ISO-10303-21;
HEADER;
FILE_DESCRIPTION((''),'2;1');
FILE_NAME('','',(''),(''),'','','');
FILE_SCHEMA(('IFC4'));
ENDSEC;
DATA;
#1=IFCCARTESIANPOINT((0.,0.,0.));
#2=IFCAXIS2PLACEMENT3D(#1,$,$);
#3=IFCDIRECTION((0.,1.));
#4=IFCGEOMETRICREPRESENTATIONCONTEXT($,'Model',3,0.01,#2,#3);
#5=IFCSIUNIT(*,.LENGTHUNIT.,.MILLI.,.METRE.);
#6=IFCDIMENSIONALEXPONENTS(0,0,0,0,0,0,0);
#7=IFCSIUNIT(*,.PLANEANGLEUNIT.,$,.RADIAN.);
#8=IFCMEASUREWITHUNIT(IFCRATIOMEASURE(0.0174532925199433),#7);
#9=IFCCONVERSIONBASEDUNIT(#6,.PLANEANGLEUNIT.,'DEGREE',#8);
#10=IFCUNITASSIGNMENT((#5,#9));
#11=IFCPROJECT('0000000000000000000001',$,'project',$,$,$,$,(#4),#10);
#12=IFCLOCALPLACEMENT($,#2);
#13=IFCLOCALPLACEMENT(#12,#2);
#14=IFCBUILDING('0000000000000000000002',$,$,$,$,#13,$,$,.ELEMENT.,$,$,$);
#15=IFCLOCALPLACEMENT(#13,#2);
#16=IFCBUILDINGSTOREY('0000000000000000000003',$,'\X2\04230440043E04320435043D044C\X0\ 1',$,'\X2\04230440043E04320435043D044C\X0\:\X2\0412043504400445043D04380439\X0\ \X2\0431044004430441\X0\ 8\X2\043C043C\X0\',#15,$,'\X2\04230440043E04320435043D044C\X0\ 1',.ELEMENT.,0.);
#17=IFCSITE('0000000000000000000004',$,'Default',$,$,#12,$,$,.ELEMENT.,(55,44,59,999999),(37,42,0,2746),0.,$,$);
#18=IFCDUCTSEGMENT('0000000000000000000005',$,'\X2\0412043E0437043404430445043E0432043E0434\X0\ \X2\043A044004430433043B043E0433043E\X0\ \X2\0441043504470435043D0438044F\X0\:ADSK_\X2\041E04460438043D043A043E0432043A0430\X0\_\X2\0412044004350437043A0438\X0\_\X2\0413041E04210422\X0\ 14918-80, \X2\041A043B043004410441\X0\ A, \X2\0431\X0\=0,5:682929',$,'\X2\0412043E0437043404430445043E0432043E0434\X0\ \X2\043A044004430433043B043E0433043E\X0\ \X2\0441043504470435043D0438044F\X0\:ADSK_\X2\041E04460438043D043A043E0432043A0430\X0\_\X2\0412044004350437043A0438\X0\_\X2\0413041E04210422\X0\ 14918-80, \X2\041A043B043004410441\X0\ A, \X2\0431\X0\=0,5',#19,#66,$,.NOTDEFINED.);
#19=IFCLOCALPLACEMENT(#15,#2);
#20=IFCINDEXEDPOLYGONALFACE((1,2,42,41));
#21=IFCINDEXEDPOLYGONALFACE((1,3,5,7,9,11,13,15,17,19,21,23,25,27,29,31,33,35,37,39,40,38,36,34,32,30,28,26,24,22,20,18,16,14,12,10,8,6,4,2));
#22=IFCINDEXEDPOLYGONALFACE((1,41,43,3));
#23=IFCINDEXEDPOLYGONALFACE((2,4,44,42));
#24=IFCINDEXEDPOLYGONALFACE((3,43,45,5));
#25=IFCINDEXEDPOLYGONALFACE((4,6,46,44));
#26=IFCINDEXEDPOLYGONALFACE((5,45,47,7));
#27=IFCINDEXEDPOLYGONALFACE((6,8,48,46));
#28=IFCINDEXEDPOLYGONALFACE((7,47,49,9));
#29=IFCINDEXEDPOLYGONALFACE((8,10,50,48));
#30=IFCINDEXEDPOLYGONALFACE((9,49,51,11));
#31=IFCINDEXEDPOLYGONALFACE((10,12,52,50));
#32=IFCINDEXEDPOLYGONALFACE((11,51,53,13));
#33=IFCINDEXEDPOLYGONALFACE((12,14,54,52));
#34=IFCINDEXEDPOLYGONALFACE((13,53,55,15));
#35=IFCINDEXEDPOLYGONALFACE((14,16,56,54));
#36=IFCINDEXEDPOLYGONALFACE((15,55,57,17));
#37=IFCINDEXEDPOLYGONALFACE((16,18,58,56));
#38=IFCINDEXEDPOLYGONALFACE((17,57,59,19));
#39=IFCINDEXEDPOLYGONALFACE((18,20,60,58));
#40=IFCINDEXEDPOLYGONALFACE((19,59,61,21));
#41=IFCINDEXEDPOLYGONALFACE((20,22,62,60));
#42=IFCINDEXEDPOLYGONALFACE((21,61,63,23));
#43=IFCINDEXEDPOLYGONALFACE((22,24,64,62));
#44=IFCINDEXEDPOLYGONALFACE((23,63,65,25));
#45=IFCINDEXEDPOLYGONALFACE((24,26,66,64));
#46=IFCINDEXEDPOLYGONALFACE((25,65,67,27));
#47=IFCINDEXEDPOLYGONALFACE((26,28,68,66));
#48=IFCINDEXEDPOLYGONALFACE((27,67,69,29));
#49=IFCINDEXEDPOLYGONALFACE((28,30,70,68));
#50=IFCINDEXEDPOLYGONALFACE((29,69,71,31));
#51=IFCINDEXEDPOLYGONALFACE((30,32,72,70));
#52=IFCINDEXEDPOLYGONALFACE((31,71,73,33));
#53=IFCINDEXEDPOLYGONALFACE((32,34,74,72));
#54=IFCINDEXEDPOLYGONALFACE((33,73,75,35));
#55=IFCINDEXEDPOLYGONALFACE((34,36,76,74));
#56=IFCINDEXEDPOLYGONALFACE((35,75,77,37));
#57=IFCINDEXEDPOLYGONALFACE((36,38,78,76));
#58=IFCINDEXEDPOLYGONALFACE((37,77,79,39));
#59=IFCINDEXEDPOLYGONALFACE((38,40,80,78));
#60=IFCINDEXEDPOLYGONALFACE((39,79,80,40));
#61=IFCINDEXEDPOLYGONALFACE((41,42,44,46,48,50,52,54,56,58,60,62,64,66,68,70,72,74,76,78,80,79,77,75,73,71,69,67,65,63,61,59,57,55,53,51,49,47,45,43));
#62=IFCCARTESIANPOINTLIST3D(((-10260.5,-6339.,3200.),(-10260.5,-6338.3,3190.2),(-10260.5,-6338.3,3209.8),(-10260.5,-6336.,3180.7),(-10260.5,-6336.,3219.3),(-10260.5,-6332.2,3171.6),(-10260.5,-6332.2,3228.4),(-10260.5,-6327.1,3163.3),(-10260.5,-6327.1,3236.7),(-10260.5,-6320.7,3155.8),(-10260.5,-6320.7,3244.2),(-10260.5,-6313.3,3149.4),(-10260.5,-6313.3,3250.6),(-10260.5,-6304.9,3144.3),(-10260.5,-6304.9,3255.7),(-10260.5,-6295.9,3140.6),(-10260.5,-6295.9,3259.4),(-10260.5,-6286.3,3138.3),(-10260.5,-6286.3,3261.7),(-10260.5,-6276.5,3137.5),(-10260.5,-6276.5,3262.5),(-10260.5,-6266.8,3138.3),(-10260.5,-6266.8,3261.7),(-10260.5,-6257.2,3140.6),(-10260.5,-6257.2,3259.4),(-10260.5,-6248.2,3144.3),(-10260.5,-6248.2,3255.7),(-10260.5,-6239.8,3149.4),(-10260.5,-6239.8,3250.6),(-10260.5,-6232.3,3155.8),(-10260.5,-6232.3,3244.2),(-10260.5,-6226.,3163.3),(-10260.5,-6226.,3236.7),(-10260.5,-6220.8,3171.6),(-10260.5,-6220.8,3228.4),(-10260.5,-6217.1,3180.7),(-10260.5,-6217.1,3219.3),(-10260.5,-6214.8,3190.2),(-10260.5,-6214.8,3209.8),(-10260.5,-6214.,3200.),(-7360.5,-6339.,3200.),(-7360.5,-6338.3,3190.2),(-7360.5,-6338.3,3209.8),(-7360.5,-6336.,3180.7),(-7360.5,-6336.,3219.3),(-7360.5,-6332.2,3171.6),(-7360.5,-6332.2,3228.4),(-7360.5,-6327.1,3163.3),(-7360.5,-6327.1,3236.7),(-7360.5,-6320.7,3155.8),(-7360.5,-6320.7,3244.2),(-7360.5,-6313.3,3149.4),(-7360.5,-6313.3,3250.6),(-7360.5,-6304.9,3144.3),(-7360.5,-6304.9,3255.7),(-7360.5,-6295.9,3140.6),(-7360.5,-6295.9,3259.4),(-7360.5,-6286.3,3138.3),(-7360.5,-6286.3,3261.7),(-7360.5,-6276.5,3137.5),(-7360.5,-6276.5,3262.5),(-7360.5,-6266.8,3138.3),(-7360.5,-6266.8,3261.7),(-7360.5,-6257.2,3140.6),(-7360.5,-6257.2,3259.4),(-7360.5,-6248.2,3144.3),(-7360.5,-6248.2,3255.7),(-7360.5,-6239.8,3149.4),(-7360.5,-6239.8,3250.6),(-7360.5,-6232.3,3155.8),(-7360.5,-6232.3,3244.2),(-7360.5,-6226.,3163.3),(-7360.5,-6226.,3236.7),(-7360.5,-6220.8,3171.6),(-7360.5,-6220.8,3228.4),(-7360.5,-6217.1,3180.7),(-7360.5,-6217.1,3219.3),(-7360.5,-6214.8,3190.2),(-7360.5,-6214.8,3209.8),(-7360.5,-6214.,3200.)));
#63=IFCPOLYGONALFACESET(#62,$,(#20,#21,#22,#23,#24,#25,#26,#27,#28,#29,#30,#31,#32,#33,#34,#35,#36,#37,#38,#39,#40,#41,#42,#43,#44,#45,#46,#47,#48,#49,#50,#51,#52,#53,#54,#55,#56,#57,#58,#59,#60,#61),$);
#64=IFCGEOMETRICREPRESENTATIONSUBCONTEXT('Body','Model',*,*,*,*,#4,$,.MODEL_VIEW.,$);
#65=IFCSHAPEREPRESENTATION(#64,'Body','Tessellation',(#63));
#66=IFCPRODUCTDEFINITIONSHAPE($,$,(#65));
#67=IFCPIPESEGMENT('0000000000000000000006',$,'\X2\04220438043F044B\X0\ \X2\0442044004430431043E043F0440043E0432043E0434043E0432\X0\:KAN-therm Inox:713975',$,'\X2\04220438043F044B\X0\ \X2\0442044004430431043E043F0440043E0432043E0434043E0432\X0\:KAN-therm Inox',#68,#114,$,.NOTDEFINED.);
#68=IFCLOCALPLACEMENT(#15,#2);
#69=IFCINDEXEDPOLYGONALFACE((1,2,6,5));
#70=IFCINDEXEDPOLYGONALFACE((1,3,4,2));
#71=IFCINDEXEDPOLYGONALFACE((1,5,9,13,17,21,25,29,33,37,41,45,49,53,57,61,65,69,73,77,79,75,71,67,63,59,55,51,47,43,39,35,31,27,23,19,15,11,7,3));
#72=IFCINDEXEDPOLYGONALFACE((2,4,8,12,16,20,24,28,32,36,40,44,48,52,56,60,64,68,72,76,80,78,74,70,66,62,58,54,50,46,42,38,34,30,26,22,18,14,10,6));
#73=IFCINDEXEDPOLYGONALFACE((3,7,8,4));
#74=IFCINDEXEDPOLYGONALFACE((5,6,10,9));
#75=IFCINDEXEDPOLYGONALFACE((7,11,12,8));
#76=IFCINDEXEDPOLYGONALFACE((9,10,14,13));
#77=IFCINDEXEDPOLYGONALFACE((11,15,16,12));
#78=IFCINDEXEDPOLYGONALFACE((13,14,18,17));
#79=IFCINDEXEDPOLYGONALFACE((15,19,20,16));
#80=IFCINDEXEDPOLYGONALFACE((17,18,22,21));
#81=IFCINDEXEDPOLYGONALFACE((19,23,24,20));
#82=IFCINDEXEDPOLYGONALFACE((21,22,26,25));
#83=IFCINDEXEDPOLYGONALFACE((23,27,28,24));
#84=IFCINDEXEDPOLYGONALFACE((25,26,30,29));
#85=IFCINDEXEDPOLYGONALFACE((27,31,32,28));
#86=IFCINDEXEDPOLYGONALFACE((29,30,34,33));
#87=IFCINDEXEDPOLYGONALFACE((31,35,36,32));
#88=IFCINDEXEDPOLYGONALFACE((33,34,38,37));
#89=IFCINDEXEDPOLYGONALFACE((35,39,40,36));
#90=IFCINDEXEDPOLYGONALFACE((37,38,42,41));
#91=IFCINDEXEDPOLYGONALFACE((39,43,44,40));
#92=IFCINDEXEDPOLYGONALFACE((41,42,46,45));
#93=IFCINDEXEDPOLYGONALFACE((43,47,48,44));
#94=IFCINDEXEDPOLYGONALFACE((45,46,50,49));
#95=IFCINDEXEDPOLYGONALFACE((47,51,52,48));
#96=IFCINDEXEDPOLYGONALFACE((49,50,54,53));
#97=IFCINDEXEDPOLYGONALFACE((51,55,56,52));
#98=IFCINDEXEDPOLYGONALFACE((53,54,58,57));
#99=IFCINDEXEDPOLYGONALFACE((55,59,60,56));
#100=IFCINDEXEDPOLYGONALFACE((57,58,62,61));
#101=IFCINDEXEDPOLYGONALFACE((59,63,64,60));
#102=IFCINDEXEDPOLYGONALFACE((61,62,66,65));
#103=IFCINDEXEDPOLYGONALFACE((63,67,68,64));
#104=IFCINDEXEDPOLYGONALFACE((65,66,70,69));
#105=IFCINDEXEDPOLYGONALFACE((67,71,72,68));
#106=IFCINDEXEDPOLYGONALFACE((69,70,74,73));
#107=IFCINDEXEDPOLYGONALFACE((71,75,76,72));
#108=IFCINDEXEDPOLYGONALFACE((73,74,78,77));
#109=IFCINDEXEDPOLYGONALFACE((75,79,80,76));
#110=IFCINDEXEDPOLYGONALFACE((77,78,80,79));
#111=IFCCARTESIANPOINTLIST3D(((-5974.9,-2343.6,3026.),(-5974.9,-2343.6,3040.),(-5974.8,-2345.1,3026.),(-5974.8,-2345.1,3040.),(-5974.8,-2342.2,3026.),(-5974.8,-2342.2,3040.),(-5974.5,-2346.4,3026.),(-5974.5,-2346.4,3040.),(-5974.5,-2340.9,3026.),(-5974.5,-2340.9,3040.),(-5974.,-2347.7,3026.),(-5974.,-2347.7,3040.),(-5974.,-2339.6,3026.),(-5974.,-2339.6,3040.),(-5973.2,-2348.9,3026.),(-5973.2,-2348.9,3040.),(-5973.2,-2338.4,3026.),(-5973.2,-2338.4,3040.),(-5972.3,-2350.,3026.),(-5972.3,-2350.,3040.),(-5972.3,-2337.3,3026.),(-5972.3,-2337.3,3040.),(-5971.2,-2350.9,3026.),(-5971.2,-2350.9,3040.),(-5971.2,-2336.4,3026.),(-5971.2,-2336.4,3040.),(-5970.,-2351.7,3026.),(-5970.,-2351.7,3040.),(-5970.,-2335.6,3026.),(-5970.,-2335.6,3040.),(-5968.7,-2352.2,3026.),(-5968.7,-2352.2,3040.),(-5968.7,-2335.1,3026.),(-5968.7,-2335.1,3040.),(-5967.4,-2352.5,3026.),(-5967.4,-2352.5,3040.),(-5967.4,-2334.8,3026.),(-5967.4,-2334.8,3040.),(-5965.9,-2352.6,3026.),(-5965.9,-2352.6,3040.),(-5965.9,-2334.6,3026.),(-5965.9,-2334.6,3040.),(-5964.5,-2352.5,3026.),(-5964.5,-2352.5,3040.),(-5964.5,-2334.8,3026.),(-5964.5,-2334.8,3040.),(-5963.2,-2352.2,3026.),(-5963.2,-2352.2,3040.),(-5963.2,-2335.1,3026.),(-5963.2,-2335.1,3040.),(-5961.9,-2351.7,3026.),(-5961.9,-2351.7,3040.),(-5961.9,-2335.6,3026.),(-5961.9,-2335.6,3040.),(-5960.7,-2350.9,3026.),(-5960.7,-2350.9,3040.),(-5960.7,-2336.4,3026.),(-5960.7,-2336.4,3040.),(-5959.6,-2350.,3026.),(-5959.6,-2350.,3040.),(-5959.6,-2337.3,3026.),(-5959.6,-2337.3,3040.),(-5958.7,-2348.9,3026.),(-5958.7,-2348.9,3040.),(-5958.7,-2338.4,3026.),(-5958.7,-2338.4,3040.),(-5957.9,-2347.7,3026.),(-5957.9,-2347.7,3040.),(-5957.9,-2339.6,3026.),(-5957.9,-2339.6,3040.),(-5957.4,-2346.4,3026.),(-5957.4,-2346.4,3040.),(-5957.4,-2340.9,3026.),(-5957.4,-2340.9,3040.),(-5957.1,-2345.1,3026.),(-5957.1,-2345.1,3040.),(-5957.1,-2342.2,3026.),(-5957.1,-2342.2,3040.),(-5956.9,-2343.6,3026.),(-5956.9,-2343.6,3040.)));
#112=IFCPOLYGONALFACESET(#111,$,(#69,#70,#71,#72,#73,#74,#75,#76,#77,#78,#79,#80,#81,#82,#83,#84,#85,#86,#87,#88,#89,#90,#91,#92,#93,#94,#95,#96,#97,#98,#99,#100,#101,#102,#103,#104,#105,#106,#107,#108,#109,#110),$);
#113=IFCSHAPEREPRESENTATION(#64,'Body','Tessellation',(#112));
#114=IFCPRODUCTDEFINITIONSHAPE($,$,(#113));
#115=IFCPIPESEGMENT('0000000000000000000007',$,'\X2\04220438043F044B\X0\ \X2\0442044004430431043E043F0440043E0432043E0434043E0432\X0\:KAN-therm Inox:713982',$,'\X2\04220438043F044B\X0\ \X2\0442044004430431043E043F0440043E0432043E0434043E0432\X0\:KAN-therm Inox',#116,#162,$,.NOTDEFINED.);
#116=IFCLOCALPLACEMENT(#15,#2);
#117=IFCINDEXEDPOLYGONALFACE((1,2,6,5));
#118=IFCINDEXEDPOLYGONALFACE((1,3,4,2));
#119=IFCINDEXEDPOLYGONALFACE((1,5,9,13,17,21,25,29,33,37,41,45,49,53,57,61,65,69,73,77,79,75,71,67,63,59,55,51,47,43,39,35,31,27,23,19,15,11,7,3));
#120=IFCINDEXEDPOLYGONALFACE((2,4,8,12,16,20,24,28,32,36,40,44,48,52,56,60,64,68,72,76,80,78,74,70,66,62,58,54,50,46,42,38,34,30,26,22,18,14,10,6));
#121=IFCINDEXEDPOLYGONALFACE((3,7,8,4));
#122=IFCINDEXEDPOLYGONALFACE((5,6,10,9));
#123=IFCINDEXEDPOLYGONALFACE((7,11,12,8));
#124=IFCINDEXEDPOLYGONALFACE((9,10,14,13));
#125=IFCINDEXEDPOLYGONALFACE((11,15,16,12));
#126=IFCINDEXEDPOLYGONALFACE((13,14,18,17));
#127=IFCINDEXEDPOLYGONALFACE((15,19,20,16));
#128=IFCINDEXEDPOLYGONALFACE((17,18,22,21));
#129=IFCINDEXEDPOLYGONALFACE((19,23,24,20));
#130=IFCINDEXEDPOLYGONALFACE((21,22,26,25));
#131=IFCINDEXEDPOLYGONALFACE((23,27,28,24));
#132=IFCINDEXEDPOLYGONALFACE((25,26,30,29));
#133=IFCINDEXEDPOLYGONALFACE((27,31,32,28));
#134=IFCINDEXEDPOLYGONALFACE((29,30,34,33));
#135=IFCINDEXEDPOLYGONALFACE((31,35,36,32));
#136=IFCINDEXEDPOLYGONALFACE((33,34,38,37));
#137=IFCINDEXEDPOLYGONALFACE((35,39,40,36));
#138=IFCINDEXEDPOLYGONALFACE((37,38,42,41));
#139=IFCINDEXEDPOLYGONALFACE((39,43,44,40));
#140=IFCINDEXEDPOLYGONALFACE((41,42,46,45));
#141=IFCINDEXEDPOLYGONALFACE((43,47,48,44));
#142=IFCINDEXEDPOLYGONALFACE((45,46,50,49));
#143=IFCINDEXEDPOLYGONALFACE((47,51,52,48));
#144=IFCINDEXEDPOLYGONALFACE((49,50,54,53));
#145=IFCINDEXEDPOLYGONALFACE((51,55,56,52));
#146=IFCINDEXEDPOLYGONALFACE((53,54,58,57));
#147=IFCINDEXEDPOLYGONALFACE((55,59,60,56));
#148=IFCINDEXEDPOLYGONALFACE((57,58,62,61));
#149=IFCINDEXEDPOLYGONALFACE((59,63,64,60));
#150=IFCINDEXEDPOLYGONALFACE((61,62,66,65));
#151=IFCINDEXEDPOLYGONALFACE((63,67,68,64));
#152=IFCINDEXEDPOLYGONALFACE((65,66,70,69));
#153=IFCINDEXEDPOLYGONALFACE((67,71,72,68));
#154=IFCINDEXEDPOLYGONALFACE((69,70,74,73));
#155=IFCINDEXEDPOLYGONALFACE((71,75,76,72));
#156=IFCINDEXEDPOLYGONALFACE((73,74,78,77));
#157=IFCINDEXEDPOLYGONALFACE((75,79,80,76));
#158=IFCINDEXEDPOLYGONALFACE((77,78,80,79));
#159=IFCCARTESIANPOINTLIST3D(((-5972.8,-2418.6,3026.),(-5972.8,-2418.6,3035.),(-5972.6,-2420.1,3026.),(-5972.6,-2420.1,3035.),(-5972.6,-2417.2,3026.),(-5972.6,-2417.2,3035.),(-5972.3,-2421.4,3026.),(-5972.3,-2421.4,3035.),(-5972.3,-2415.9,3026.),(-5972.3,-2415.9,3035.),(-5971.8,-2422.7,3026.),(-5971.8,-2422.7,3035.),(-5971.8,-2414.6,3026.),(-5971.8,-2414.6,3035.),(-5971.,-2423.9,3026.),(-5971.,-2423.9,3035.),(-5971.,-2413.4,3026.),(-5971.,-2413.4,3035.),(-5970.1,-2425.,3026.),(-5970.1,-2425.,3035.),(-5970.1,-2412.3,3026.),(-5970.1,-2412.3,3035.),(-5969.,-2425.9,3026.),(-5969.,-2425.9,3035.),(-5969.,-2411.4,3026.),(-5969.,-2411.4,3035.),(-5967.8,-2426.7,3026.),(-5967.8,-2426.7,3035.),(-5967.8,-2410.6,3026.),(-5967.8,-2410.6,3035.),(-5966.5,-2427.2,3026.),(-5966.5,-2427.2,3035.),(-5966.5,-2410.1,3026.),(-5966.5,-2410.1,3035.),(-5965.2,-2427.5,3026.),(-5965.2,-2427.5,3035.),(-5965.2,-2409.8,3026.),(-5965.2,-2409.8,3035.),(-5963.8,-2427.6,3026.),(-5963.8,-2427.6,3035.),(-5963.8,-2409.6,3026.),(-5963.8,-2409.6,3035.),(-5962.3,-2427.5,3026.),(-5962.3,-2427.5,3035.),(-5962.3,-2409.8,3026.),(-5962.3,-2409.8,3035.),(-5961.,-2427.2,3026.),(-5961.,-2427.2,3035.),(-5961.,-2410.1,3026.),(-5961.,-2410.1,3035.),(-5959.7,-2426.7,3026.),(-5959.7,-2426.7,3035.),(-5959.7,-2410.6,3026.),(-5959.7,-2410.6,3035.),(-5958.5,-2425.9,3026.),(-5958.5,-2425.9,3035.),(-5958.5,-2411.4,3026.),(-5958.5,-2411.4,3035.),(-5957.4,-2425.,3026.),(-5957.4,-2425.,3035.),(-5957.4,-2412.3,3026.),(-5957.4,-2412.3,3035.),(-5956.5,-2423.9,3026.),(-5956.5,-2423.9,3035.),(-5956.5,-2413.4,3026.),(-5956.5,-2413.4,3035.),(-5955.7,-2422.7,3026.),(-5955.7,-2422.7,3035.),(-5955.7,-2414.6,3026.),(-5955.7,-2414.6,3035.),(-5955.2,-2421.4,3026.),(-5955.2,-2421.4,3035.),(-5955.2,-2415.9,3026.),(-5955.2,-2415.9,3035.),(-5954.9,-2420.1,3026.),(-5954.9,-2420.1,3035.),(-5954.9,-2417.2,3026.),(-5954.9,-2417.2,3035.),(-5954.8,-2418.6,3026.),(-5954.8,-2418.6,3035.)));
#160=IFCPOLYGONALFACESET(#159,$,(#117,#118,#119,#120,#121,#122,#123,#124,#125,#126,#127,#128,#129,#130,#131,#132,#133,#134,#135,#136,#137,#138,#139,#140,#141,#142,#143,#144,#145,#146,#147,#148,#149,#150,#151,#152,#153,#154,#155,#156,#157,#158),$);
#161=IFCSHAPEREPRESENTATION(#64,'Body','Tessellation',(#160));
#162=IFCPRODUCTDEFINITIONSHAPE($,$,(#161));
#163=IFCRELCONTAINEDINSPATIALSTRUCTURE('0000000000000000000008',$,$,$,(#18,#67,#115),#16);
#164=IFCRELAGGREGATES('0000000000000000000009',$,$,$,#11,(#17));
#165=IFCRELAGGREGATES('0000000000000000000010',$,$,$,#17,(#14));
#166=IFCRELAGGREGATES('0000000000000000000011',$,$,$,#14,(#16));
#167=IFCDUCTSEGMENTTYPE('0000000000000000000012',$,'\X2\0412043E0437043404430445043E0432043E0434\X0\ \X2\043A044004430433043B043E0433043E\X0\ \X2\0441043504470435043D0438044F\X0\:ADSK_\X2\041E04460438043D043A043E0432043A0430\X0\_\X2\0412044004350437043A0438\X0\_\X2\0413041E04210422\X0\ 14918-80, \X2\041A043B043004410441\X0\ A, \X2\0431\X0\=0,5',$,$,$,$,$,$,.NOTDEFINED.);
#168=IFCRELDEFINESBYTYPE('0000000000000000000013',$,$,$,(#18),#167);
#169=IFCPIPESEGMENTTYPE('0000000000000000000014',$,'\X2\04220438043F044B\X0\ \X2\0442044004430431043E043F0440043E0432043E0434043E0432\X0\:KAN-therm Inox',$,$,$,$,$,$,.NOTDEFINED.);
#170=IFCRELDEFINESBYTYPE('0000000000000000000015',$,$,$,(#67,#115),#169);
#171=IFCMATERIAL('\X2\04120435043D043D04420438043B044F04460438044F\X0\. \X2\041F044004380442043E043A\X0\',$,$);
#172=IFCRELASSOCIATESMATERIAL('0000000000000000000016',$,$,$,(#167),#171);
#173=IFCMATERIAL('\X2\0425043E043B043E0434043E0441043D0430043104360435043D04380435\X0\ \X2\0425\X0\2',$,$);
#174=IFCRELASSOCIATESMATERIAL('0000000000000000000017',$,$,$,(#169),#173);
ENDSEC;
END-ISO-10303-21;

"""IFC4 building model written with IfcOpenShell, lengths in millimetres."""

from ifc_helpers import new_model, entity, si_unit, converted_unit, direction, frame, origin, place, context, subcontext, project, spatial, indexed_curve, outline, extrude, material, type_object, element, save


model = new_model("IFC4")

# Units and contexts
model_context = context("Model", 3, precision=0.01, world=origin(), true_north=direction((0.0, 1.0)))
body_context = subcontext(model_context, "Body", "Model", "MODEL_VIEW")
ifc_project = project(units=[si_unit("LENGTHUNIT", "METRE", prefix="MILLI"), converted_unit("PLANEANGLEUNIT", "DEGREE", entity("IfcRatioMeasure", 0.0174532925199433), si_unit("PLANEANGLEUNIT", "RADIAN"), dimensions=[0, 0, 0, 0, 0, 0, 0])], contexts=[model_context])

# Site, building, storey
site_placement = place(None, origin())
site = spatial("IfcSite", under=ifc_project, at=site_placement, Name="Default", CompositionType="ELEMENT", RefLatitude=(55, 44, 59, 999999), RefLongitude=(37, 42, 0, 2746), RefElevation=0.0)
building_placement = place(site_placement, origin())
building = spatial("IfcBuilding", under=site, at=building_placement, CompositionType="ELEMENT")
storey_placement = place(building_placement, origin())
storey = spatial("IfcBuildingStorey", under=building, at=storey_placement, Name="Уровень 1", ObjectType="Уровень:Верхний брус 8мм", LongName="Уровень 1", CompositionType="ELEMENT", Elevation=0.0)

# Shared definitions
ifc_material_1 = material(Name="Холодоснабжение Х2")

# Duct segment
ifc_material_2 = material(Name="Веннтиляция. Приток")
duct_segment_type = type_object("IfcDuctSegmentType", Name="Воздуховод круглого сечения:ADSK_Оцинковка_Врезки_ГОСТ 14918-80, Класс A, б=0,5", PredefinedType="NOTDEFINED", material=ifc_material_2)
duct_segment_1_placement = place(storey_placement, origin())
element("IfcDuctSegment", 1, at=duct_segment_1_placement, inside=storey, type_object=duct_segment_type, Name="Воздуховод круглого сечения:ADSK_Оцинковка_Врезки_ГОСТ 14918-80, Класс A, б=0,5:682929", ObjectType="Воздуховод круглого сечения:ADSK_Оцинковка_Врезки_ГОСТ 14918-80, Класс A, б=0,5", PredefinedType="NOTDEFINED", context=body_context, shape_type="SweptSolid", body=[
    extrude(outline(indexed_curve([(62.5, 0.0), (61.7, 9.8), (59.4, 19.3), (55.7, 28.4), (50.6, 36.7), (44.2, 44.2), (36.7, 50.6), (28.4, 55.7), (19.3, 59.4), (9.8, 61.7), (0.0, 62.5), (-9.8, 61.7), (-19.3, 59.4), (-28.4, 55.7), (-36.7, 50.6), (-44.2, 44.2), (-50.6, 36.7), (-55.7, 28.4), (-59.4, 19.3), (-61.7, 9.8), (-62.5, 0.0), (-61.7, -9.8), (-59.4, -19.3), (-55.7, -28.4), (-50.6, -36.7), (-44.2, -44.2), (-36.7, -50.6), (-28.4, -55.7), (-19.3, -59.4), (-9.8, -61.7), (0.0, -62.5), (9.8, -61.7), (19.3, -59.4), (28.4, -55.7), (36.7, -50.6), (44.2, -44.2), (50.6, -36.7), (55.7, -28.4), (59.4, -19.3), (61.7, -9.8), (62.5, 0.0)], self_intersect=False)), frame((-10260.5, -6276.5, 3200.0), z_axis=(1.0, 0.0, 0.0), x_axis=(0.0, 1.0, 0.0)), (0.0, 0.0, 1.0), 2900.0),
])

# Pipe segments
pipe_segment_type_1 = type_object("IfcPipeSegmentType", Name="Типы трубопроводов:KAN-therm Inox", PredefinedType="NOTDEFINED", material=ifc_material_1)
pipe_segment_1_placement = place(storey_placement, origin())
element("IfcPipeSegment", 2, at=pipe_segment_1_placement, inside=storey, type_object=pipe_segment_type_1, Name="Типы трубопроводов:KAN-therm Inox:713975", ObjectType="Типы трубопроводов:KAN-therm Inox", PredefinedType="NOTDEFINED", context=body_context, shape_type="SweptSolid", body=[
    extrude(outline(indexed_curve([(9.0, 0.0), (8.9, 1.4), (8.6, 2.8), (8.0, 4.1), (7.3, 5.3), (6.4, 6.4), (5.3, 7.3), (4.1, 8.0), (2.8, 8.6), (1.4, 8.9), (0.0, 9.0), (-1.4, 8.9), (-2.8, 8.6), (-4.1, 8.0), (-5.3, 7.3), (-6.4, 6.4), (-7.3, 5.3), (-8.0, 4.1), (-8.6, 2.8), (-8.9, 1.4), (-9.0, 0.0), (-8.9, -1.4), (-8.6, -2.8), (-8.0, -4.1), (-7.3, -5.3), (-6.4, -6.4), (-5.3, -7.3), (-4.1, -8.0), (-2.8, -8.6), (-1.4, -8.9), (0.0, -9.0), (1.4, -8.9), (2.8, -8.6), (4.1, -8.0), (5.3, -7.3), (6.4, -6.4), (7.3, -5.3), (8.0, -4.1), (8.6, -2.8), (8.9, -1.4), (9.0, 0.0)], self_intersect=False)), frame((-5965.9, -2343.6, 3026.0), z_axis=(0.0, 0.0, 1.0), x_axis=(-1.0, 0.0, 0.0)), (0.0, 0.0, 1.0), 14.0),
])
pipe_segment_2_placement = place(storey_placement, origin())
element("IfcPipeSegment", 3, at=pipe_segment_2_placement, inside=storey, type_object=pipe_segment_type_1, Name="Типы трубопроводов:KAN-therm Inox:713982", ObjectType="Типы трубопроводов:KAN-therm Inox", PredefinedType="NOTDEFINED", context=body_context, shape_type="SweptSolid", body=[
    extrude(outline(indexed_curve([(9.0, 0.0), (8.9, 1.4), (8.6, 2.8), (8.0, 4.1), (7.3, 5.3), (6.4, 6.4), (5.3, 7.3), (4.1, 8.0), (2.8, 8.6), (1.4, 8.9), (0.0, 9.0), (-1.4, 8.9), (-2.8, 8.6), (-4.1, 8.0), (-5.3, 7.3), (-6.4, 6.4), (-7.3, 5.3), (-8.0, 4.1), (-8.6, 2.8), (-8.9, 1.4), (-9.0, 0.0), (-8.9, -1.4), (-8.6, -2.8), (-8.0, -4.1), (-7.3, -5.3), (-6.4, -6.4), (-5.3, -7.3), (-4.1, -8.0), (-2.8, -8.6), (-1.4, -8.9), (0.0, -9.0), (1.4, -8.9), (2.8, -8.6), (4.1, -8.0), (5.3, -7.3), (6.4, -6.4), (7.3, -5.3), (8.0, -4.1), (8.6, -2.8), (8.9, -1.4), (9.0, 0.0)], self_intersect=False)), frame((-5963.8, -2418.6, 3026.0), z_axis=(0.0, 0.0, 1.0), x_axis=(-1.0, 0.0, 0.0)), (0.0, 0.0, 1.0), 9.0),
])

save(model, "model.ifc")
